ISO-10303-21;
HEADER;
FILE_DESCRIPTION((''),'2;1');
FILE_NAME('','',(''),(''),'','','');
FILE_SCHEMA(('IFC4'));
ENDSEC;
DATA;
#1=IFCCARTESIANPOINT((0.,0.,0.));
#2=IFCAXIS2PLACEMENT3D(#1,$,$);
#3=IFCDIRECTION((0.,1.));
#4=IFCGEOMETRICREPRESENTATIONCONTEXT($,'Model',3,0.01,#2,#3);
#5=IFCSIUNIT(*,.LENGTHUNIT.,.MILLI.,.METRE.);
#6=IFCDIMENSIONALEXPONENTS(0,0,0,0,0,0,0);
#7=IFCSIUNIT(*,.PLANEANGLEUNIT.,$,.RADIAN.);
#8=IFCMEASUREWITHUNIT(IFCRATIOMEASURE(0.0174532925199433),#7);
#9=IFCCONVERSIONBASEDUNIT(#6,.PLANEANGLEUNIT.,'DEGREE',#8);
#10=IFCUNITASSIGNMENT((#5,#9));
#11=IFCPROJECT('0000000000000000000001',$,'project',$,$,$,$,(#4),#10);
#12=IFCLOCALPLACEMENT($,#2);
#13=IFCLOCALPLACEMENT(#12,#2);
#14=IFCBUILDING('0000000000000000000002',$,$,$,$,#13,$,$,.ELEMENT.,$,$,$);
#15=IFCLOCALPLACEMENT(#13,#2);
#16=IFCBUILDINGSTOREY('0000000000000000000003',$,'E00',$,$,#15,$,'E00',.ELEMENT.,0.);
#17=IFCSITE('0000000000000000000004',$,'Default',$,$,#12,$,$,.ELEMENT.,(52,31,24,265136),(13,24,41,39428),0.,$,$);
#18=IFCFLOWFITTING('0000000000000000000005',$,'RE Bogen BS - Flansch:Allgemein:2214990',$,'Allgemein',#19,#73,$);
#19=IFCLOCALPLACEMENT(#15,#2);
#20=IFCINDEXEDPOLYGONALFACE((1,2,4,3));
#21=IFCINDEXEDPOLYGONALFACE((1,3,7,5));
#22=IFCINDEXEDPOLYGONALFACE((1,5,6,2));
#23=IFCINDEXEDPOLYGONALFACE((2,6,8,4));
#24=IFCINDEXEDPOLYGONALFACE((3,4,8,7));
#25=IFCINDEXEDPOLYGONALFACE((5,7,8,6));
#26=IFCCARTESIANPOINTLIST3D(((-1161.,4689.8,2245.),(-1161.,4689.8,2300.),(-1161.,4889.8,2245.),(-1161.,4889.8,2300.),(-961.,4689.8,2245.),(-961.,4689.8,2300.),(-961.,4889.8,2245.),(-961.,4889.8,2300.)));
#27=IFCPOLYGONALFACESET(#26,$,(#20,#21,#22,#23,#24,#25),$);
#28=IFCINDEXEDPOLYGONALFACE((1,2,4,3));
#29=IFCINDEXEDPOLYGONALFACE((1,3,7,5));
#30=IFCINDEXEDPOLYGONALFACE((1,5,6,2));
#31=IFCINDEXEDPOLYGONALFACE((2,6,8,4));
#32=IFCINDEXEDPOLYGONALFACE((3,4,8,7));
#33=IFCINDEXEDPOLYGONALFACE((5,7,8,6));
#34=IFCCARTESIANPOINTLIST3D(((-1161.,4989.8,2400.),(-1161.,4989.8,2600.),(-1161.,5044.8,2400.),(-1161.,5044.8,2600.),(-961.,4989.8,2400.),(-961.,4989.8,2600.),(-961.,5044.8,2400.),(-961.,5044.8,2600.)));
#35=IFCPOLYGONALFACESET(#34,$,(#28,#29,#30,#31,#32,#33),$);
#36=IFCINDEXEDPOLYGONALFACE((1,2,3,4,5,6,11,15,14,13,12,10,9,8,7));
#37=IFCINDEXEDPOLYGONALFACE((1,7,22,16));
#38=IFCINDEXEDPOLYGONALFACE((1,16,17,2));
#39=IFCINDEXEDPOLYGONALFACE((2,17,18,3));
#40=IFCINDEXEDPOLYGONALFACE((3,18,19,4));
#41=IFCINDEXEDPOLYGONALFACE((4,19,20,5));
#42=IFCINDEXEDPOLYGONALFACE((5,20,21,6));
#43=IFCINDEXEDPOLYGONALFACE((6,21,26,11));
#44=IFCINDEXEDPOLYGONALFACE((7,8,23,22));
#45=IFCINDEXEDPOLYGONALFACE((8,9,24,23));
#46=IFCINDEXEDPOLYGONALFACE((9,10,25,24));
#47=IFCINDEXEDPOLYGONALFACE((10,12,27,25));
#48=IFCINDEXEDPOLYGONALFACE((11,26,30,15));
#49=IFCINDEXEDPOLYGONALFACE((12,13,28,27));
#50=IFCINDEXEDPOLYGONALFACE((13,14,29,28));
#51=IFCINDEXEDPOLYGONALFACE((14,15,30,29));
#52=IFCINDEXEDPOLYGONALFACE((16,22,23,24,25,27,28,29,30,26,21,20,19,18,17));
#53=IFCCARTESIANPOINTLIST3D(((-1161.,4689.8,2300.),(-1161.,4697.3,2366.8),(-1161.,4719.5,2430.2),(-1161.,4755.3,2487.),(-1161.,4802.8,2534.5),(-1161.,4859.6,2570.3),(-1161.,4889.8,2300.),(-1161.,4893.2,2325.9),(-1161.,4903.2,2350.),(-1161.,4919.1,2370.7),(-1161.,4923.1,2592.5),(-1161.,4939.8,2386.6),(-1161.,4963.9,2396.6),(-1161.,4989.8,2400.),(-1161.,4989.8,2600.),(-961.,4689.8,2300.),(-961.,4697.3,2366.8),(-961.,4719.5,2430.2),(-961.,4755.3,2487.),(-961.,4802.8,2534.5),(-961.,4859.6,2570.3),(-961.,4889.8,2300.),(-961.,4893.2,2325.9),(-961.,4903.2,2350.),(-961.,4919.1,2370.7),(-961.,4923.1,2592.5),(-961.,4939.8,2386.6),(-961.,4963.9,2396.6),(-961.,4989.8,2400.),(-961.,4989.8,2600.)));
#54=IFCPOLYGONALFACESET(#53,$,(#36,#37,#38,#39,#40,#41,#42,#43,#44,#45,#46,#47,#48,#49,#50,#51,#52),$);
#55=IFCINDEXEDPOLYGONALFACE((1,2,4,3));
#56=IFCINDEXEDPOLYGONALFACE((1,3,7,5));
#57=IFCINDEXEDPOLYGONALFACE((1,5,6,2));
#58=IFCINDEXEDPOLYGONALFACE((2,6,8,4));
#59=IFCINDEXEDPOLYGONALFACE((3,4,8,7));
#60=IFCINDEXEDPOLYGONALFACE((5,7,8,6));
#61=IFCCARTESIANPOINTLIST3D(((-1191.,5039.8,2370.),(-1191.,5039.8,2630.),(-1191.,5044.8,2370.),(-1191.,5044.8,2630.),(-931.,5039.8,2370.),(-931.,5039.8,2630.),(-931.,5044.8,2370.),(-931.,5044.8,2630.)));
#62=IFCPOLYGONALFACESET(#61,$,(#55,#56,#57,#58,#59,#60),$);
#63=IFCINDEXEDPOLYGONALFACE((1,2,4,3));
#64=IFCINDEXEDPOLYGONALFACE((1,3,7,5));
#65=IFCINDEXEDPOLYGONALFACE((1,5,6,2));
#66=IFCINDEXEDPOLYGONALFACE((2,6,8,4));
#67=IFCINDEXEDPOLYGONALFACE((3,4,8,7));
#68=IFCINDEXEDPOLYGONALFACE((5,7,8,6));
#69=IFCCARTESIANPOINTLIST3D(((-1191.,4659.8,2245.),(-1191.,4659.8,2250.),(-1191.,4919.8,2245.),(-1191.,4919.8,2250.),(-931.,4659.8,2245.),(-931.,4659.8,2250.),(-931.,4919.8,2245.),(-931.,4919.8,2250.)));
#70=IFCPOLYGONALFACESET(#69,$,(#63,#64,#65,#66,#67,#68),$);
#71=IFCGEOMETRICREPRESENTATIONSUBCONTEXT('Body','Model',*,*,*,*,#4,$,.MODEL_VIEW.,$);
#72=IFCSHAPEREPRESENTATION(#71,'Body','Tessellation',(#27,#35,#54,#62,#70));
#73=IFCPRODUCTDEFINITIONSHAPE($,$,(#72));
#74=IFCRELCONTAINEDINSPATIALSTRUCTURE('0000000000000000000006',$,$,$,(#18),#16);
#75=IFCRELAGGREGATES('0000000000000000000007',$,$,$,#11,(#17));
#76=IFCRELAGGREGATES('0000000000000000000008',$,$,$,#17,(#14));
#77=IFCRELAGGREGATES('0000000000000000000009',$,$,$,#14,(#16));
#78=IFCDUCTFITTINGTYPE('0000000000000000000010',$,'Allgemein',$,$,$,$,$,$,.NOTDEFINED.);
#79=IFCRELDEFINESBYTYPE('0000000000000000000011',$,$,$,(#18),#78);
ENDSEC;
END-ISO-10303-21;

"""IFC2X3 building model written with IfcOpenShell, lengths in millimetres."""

from ifc_helpers import new_model, entity, si_unit, converted_unit, direction, frame, frame_2d, origin, place, context, subcontext, project, spatial, polyline, circle_curve, parameter, trimmed, segment, composite_curve, rectangle, outline, extrude, source, transform, mapped, type_object, type_shapes, element, save


model = new_model("IFC2X3")

# Units and contexts
model_context = context("Model", 3, precision=0.01, world=origin(), true_north=direction((0.0, 1.0)))
body_context = subcontext(model_context, "Body", "Model", "MODEL_VIEW")
ifc_project = project(units=[si_unit("LENGTHUNIT", "METRE", prefix="MILLI"), converted_unit("PLANEANGLEUNIT", "DEGREE", entity("IfcRatioMeasure", 0.0174532925199433), si_unit("PLANEANGLEUNIT", "RADIAN"), dimensions=[0, 0, 0, 0, 0, 0, 0])], contexts=[model_context])

# Site, building, storey
site_placement = place(None, origin())
site = spatial("IfcSite", under=ifc_project, at=site_placement, Name="Default", CompositionType="ELEMENT", RefLatitude=(52, 31, 24, 265136), RefLongitude=(13, 24, 41, 39428), RefElevation=0.0)
building_placement = place(site_placement, origin())
building = spatial("IfcBuilding", under=site, at=building_placement, CompositionType="ELEMENT")
storey_placement = place(building_placement, origin())
storey = spatial("IfcBuildingStorey", under=building, at=storey_placement, Name="E00", LongName="E00", CompositionType="ELEMENT", Elevation=0.0)

# Flow fitting
duct_fitting_type = type_object("IfcDuctFittingType", Name="Allgemein", PredefinedType="NOTDEFINED")
shared_shape = source(origin(), body_context, "Body", "SweptSolid", [
    extrude(rectangle(XDim=55.0, YDim=200.0, at=frame_2d((0.0, 0.0), x_axis=(1.0, 0.0))), frame((0.0, 227.5, -100.0), z_axis=(0.0, 0.0, 1.0), x_axis=(0.0, 1.0, 0.0)), (0.0, 0.0, 1.0), 200.0),
    extrude(rectangle(XDim=200.0, YDim=55.0, at=frame_2d((0.0, 0.0), x_axis=(1.0, 0.0))), frame((-227.5, 0.0, -100.0), z_axis=(0.0, 0.0, 1.0), x_axis=(0.0, -1.0, 0.0)), (0.0, 0.0, 1.0), 200.0),
    extrude(outline(composite_curve([segment(polyline([(-200.0, -100.0), (0.0, -100.0)]), True, "CONTINUOUS"), segment(trimmed(circle_curve(frame_2d((100.0, -100.0), x_axis=(0.0, 1.0)), 100.0), [parameter(0.0)], [parameter(90.0)], True, "PARAMETER"), False, "CONTINUOUS"), segment(polyline([(100.0, 0.0), (100.0, 200.0)]), True, "CONTINUOUS"), segment(trimmed(circle_curve(frame_2d((100.0, -100.0), x_axis=(0.0, 1.0)), 300.0), [parameter(0.0)], [parameter(90.0)], True, "PARAMETER"), True, "CONTINUOUS")], self_intersect=False)), frame((-100.0, 100.0, -100.0), z_axis=(0.0, 0.0, 1.0), x_axis=(-1.0, 0.0, 0.0)), (0.0, 0.0, 1.0), 200.0),
    extrude(rectangle(XDim=5.0, YDim=260.0, at=frame_2d((0.0, 0.0), x_axis=(1.0, 0.0))), frame((-252.5, 0.0, -130.0)), (0.0, 0.0, 1.0), 260.0),
    extrude(rectangle(XDim=5.0, YDim=260.0, at=frame_2d((0.0, 0.0), x_axis=(1.0, 0.0))), frame((0.0, 252.5, -130.0), z_axis=(0.0, 0.0, 1.0), x_axis=(0.0, 1.0, 0.0)), (0.0, 0.0, 1.0), 260.0),
])
type_shapes(duct_fitting_type, [shared_shape])
for number, where, z_axis, x_axis, name in (
    (1, (-1061.0, 4789.8, 2500.0), (1.0, 0.0, 0.0), (0.0, -1.0, 0.0), "RE Bogen BS - Flansch:Allgemein:2214990"),
):
    element("IfcFlowFitting", number, at=place(storey_placement, frame(where, z_axis=z_axis, x_axis=x_axis)), inside=storey, type_object=duct_fitting_type, Name=name, ObjectType="Allgemein", context=body_context, shape_type="MappedRepresentation", body=[
        mapped(shared_shape, transform((0.0, 0.0, 0.0), scale=1.0)),
    ])

save(model, "model.ifc")
